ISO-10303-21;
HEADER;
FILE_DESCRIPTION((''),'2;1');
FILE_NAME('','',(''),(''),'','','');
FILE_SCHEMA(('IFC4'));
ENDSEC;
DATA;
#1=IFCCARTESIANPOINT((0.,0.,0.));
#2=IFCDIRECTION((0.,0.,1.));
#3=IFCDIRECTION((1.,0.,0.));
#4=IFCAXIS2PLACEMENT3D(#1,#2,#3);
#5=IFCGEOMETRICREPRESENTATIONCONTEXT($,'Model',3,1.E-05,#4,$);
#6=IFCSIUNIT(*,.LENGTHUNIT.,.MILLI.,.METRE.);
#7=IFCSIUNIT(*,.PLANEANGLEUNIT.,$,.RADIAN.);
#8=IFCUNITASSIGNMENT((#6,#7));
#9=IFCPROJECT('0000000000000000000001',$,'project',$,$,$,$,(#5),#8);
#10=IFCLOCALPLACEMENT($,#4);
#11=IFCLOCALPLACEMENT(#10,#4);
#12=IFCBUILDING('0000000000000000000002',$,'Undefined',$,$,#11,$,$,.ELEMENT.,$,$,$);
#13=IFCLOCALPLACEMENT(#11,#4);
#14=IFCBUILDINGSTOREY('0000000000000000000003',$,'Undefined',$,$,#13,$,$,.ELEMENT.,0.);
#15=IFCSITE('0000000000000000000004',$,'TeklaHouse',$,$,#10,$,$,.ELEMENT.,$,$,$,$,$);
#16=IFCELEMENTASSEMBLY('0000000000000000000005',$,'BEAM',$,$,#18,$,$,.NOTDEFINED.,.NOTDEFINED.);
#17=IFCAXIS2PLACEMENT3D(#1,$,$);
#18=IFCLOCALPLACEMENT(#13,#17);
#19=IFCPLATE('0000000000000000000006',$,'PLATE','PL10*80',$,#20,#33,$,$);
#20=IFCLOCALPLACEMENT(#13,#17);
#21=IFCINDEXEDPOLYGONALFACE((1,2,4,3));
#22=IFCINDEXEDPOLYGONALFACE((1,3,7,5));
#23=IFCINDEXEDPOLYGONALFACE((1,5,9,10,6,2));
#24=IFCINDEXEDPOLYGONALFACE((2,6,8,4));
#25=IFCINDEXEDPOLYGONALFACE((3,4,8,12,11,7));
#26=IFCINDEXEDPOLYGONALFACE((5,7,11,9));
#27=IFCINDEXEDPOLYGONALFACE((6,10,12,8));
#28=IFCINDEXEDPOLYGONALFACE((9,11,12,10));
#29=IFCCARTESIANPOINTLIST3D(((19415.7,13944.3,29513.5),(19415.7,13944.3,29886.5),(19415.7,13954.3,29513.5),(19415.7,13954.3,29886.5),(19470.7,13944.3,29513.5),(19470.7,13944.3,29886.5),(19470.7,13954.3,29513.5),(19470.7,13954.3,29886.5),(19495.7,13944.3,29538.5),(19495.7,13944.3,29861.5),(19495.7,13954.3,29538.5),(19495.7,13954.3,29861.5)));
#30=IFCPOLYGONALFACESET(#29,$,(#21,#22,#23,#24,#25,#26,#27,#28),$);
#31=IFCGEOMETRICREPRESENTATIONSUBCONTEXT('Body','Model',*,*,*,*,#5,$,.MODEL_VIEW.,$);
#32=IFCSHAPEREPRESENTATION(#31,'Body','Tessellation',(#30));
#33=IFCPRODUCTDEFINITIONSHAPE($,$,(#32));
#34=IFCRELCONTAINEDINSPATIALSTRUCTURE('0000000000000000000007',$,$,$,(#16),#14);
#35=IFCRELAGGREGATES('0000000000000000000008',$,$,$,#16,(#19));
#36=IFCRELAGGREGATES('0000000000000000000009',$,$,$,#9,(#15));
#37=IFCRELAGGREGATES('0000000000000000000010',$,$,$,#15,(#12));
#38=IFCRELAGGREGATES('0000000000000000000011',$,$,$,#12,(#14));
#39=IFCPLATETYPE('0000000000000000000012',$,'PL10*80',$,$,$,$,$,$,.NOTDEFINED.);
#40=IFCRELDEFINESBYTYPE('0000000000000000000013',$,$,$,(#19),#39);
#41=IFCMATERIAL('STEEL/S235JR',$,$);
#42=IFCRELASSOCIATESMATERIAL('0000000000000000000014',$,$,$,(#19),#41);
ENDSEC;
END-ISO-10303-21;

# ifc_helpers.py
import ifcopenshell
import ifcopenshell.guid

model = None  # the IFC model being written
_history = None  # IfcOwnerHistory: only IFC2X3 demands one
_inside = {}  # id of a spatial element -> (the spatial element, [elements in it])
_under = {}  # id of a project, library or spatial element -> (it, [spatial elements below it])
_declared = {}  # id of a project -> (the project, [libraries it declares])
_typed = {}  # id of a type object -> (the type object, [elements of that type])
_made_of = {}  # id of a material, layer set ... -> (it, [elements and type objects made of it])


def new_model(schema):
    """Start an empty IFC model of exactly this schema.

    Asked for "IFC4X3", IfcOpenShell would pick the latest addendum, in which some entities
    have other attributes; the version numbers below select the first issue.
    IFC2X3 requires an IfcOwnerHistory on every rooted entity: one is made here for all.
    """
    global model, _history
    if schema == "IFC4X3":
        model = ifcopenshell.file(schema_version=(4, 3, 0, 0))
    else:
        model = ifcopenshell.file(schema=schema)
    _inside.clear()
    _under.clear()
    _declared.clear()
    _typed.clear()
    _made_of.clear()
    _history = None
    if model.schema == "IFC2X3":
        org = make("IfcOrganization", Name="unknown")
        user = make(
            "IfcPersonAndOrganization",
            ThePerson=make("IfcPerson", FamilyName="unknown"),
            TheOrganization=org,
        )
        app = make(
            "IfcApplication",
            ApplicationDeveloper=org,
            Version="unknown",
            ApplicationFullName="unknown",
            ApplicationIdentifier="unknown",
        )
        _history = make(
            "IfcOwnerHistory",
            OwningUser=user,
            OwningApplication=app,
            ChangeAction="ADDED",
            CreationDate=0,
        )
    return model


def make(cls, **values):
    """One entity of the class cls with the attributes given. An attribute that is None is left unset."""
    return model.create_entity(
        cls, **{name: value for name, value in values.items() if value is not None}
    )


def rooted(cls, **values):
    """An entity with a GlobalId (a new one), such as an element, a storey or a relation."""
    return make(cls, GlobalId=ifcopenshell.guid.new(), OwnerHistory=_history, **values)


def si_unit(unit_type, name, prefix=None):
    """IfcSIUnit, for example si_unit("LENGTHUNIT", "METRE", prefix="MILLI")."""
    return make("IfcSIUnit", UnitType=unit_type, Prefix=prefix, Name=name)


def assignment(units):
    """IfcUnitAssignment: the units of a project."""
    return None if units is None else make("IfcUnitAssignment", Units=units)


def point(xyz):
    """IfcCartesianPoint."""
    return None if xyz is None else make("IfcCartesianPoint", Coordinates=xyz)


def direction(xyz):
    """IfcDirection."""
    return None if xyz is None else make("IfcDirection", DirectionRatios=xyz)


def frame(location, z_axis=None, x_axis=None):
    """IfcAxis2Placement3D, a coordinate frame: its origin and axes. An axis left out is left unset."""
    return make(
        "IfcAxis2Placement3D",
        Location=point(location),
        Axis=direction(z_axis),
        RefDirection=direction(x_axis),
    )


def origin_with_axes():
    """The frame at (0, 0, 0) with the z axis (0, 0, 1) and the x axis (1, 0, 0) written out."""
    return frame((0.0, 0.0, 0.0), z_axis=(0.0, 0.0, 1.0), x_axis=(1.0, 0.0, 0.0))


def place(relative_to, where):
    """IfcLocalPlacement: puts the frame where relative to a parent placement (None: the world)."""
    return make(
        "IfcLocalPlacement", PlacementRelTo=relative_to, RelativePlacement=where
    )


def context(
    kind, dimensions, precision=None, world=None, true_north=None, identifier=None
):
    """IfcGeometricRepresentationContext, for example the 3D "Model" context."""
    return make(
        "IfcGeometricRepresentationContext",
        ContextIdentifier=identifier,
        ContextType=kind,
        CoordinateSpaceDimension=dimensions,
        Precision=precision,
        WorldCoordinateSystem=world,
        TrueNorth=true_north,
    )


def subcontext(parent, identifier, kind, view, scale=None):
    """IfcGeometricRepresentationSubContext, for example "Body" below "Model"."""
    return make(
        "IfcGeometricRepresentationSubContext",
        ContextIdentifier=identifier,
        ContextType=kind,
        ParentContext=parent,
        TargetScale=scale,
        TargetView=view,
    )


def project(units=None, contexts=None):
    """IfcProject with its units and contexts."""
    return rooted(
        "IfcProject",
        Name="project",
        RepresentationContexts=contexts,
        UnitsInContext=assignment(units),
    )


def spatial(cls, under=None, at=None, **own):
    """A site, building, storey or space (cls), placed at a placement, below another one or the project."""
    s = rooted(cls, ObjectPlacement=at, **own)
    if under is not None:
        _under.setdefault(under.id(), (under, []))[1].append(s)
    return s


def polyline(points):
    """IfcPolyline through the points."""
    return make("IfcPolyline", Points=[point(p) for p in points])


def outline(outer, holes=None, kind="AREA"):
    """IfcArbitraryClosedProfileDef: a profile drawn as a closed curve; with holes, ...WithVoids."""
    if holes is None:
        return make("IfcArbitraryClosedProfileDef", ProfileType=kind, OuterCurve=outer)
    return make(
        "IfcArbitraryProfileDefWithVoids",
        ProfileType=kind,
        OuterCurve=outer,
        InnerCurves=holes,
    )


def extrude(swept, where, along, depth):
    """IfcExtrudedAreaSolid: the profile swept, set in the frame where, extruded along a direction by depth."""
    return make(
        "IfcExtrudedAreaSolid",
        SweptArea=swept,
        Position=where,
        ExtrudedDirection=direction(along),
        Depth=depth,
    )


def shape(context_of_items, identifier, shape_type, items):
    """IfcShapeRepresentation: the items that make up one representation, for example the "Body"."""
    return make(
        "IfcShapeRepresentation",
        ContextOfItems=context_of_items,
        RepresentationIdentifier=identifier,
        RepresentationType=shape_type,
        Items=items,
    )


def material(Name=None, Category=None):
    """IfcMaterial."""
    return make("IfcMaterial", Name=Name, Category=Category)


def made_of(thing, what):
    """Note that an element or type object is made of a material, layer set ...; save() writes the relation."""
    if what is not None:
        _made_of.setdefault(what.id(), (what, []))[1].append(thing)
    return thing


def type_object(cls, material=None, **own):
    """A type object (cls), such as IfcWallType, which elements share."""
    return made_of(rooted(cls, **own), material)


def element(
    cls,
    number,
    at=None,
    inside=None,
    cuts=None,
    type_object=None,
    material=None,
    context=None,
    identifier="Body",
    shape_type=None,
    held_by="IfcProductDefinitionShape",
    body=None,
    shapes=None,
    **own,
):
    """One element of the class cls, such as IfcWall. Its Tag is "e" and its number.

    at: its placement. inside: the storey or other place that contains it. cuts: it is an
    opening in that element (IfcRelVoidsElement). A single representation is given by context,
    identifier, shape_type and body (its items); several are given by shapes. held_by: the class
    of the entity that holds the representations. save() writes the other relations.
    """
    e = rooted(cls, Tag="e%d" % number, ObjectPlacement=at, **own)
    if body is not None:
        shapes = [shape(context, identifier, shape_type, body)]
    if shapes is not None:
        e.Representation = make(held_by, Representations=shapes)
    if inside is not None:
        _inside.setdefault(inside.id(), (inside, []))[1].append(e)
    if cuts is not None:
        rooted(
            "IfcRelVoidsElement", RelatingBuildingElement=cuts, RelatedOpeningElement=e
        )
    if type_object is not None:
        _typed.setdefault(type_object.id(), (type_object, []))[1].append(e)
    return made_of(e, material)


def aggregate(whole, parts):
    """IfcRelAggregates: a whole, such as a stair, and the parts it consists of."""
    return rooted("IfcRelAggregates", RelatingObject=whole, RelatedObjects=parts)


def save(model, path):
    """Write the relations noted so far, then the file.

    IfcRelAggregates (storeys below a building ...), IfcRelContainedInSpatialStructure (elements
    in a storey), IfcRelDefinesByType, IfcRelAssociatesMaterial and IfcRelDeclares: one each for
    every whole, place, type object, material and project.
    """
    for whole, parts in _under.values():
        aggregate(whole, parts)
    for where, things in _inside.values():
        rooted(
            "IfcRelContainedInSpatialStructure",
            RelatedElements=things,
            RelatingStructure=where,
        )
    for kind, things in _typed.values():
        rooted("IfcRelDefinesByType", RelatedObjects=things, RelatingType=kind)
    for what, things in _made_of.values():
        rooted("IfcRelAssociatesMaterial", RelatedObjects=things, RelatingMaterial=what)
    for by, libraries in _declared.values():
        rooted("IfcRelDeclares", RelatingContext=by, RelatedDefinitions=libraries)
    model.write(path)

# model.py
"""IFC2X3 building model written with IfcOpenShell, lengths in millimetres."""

from ifc_helpers import new_model, si_unit, frame, origin_with_axes, place, context, subcontext, project, spatial, polyline, outline, extrude, material, type_object, element, aggregate, save


model = new_model("IFC2X3")

# Units and contexts
model_context = context("Model", 3, precision=1e-05, world=origin_with_axes())
body_context = subcontext(model_context, "Body", "Model", "MODEL_VIEW")
ifc_project = project(units=[si_unit("LENGTHUNIT", "METRE", prefix="MILLI"), si_unit("PLANEANGLEUNIT", "RADIAN")], contexts=[model_context])

# Site, building, storey
site_placement = place(None, origin_with_axes())
site = spatial("IfcSite", under=ifc_project, at=site_placement, Name="TeklaHouse", CompositionType="ELEMENT")
building_placement = place(site_placement, origin_with_axes())
building = spatial("IfcBuilding", under=site, at=building_placement, Name="Undefined", CompositionType="ELEMENT")
storey_placement = place(building_placement, origin_with_axes())
storey = spatial("IfcBuildingStorey", under=building, at=storey_placement, Name="Undefined", CompositionType="ELEMENT", Elevation=0.0)

# Shared definitions
ifc_material_1 = material(Name="STEEL/S235JR")

# Element assembly, plate
plate_type_1 = type_object("IfcPlateType", Name="PL10*80", PredefinedType="NOTDEFINED")
assembly_1_placement = place(storey_placement, origin_with_axes())
assembly_1 = element("IfcElementAssembly", 1, at=assembly_1_placement, inside=storey, Name="BEAM", AssemblyPlace="NOTDEFINED", PredefinedType="NOTDEFINED")
plate_1_placement = place(assembly_1_placement, frame((19495.7, 13949.3, 29513.5), z_axis=(0.0, 1.0, 0.0), x_axis=(-1.0, 0.0, 0.0)))
plate_1 = element("IfcPlate", 2, at=plate_1_placement, type_object=plate_type_1, material=ifc_material_1, Name="PLATE", Description="PL10*80", context=body_context, shape_type="SweptSolid", body=[
    extrude(outline(polyline([(0.0, 25.0), (25.0, 0.0), (80.0, 0.0), (80.0, 373.0), (25.0, 373.0), (0.0, 348.0), (0.0, 25.0)])), frame((0.0, 0.0, -5.0), z_axis=(0.0, 0.0, 1.0), x_axis=(1.0, 0.0, 0.0)), (0.0, 0.0, 1.0), 10.0),
])
aggregate(assembly_1, [plate_1])

save(model, "model.ifc")
